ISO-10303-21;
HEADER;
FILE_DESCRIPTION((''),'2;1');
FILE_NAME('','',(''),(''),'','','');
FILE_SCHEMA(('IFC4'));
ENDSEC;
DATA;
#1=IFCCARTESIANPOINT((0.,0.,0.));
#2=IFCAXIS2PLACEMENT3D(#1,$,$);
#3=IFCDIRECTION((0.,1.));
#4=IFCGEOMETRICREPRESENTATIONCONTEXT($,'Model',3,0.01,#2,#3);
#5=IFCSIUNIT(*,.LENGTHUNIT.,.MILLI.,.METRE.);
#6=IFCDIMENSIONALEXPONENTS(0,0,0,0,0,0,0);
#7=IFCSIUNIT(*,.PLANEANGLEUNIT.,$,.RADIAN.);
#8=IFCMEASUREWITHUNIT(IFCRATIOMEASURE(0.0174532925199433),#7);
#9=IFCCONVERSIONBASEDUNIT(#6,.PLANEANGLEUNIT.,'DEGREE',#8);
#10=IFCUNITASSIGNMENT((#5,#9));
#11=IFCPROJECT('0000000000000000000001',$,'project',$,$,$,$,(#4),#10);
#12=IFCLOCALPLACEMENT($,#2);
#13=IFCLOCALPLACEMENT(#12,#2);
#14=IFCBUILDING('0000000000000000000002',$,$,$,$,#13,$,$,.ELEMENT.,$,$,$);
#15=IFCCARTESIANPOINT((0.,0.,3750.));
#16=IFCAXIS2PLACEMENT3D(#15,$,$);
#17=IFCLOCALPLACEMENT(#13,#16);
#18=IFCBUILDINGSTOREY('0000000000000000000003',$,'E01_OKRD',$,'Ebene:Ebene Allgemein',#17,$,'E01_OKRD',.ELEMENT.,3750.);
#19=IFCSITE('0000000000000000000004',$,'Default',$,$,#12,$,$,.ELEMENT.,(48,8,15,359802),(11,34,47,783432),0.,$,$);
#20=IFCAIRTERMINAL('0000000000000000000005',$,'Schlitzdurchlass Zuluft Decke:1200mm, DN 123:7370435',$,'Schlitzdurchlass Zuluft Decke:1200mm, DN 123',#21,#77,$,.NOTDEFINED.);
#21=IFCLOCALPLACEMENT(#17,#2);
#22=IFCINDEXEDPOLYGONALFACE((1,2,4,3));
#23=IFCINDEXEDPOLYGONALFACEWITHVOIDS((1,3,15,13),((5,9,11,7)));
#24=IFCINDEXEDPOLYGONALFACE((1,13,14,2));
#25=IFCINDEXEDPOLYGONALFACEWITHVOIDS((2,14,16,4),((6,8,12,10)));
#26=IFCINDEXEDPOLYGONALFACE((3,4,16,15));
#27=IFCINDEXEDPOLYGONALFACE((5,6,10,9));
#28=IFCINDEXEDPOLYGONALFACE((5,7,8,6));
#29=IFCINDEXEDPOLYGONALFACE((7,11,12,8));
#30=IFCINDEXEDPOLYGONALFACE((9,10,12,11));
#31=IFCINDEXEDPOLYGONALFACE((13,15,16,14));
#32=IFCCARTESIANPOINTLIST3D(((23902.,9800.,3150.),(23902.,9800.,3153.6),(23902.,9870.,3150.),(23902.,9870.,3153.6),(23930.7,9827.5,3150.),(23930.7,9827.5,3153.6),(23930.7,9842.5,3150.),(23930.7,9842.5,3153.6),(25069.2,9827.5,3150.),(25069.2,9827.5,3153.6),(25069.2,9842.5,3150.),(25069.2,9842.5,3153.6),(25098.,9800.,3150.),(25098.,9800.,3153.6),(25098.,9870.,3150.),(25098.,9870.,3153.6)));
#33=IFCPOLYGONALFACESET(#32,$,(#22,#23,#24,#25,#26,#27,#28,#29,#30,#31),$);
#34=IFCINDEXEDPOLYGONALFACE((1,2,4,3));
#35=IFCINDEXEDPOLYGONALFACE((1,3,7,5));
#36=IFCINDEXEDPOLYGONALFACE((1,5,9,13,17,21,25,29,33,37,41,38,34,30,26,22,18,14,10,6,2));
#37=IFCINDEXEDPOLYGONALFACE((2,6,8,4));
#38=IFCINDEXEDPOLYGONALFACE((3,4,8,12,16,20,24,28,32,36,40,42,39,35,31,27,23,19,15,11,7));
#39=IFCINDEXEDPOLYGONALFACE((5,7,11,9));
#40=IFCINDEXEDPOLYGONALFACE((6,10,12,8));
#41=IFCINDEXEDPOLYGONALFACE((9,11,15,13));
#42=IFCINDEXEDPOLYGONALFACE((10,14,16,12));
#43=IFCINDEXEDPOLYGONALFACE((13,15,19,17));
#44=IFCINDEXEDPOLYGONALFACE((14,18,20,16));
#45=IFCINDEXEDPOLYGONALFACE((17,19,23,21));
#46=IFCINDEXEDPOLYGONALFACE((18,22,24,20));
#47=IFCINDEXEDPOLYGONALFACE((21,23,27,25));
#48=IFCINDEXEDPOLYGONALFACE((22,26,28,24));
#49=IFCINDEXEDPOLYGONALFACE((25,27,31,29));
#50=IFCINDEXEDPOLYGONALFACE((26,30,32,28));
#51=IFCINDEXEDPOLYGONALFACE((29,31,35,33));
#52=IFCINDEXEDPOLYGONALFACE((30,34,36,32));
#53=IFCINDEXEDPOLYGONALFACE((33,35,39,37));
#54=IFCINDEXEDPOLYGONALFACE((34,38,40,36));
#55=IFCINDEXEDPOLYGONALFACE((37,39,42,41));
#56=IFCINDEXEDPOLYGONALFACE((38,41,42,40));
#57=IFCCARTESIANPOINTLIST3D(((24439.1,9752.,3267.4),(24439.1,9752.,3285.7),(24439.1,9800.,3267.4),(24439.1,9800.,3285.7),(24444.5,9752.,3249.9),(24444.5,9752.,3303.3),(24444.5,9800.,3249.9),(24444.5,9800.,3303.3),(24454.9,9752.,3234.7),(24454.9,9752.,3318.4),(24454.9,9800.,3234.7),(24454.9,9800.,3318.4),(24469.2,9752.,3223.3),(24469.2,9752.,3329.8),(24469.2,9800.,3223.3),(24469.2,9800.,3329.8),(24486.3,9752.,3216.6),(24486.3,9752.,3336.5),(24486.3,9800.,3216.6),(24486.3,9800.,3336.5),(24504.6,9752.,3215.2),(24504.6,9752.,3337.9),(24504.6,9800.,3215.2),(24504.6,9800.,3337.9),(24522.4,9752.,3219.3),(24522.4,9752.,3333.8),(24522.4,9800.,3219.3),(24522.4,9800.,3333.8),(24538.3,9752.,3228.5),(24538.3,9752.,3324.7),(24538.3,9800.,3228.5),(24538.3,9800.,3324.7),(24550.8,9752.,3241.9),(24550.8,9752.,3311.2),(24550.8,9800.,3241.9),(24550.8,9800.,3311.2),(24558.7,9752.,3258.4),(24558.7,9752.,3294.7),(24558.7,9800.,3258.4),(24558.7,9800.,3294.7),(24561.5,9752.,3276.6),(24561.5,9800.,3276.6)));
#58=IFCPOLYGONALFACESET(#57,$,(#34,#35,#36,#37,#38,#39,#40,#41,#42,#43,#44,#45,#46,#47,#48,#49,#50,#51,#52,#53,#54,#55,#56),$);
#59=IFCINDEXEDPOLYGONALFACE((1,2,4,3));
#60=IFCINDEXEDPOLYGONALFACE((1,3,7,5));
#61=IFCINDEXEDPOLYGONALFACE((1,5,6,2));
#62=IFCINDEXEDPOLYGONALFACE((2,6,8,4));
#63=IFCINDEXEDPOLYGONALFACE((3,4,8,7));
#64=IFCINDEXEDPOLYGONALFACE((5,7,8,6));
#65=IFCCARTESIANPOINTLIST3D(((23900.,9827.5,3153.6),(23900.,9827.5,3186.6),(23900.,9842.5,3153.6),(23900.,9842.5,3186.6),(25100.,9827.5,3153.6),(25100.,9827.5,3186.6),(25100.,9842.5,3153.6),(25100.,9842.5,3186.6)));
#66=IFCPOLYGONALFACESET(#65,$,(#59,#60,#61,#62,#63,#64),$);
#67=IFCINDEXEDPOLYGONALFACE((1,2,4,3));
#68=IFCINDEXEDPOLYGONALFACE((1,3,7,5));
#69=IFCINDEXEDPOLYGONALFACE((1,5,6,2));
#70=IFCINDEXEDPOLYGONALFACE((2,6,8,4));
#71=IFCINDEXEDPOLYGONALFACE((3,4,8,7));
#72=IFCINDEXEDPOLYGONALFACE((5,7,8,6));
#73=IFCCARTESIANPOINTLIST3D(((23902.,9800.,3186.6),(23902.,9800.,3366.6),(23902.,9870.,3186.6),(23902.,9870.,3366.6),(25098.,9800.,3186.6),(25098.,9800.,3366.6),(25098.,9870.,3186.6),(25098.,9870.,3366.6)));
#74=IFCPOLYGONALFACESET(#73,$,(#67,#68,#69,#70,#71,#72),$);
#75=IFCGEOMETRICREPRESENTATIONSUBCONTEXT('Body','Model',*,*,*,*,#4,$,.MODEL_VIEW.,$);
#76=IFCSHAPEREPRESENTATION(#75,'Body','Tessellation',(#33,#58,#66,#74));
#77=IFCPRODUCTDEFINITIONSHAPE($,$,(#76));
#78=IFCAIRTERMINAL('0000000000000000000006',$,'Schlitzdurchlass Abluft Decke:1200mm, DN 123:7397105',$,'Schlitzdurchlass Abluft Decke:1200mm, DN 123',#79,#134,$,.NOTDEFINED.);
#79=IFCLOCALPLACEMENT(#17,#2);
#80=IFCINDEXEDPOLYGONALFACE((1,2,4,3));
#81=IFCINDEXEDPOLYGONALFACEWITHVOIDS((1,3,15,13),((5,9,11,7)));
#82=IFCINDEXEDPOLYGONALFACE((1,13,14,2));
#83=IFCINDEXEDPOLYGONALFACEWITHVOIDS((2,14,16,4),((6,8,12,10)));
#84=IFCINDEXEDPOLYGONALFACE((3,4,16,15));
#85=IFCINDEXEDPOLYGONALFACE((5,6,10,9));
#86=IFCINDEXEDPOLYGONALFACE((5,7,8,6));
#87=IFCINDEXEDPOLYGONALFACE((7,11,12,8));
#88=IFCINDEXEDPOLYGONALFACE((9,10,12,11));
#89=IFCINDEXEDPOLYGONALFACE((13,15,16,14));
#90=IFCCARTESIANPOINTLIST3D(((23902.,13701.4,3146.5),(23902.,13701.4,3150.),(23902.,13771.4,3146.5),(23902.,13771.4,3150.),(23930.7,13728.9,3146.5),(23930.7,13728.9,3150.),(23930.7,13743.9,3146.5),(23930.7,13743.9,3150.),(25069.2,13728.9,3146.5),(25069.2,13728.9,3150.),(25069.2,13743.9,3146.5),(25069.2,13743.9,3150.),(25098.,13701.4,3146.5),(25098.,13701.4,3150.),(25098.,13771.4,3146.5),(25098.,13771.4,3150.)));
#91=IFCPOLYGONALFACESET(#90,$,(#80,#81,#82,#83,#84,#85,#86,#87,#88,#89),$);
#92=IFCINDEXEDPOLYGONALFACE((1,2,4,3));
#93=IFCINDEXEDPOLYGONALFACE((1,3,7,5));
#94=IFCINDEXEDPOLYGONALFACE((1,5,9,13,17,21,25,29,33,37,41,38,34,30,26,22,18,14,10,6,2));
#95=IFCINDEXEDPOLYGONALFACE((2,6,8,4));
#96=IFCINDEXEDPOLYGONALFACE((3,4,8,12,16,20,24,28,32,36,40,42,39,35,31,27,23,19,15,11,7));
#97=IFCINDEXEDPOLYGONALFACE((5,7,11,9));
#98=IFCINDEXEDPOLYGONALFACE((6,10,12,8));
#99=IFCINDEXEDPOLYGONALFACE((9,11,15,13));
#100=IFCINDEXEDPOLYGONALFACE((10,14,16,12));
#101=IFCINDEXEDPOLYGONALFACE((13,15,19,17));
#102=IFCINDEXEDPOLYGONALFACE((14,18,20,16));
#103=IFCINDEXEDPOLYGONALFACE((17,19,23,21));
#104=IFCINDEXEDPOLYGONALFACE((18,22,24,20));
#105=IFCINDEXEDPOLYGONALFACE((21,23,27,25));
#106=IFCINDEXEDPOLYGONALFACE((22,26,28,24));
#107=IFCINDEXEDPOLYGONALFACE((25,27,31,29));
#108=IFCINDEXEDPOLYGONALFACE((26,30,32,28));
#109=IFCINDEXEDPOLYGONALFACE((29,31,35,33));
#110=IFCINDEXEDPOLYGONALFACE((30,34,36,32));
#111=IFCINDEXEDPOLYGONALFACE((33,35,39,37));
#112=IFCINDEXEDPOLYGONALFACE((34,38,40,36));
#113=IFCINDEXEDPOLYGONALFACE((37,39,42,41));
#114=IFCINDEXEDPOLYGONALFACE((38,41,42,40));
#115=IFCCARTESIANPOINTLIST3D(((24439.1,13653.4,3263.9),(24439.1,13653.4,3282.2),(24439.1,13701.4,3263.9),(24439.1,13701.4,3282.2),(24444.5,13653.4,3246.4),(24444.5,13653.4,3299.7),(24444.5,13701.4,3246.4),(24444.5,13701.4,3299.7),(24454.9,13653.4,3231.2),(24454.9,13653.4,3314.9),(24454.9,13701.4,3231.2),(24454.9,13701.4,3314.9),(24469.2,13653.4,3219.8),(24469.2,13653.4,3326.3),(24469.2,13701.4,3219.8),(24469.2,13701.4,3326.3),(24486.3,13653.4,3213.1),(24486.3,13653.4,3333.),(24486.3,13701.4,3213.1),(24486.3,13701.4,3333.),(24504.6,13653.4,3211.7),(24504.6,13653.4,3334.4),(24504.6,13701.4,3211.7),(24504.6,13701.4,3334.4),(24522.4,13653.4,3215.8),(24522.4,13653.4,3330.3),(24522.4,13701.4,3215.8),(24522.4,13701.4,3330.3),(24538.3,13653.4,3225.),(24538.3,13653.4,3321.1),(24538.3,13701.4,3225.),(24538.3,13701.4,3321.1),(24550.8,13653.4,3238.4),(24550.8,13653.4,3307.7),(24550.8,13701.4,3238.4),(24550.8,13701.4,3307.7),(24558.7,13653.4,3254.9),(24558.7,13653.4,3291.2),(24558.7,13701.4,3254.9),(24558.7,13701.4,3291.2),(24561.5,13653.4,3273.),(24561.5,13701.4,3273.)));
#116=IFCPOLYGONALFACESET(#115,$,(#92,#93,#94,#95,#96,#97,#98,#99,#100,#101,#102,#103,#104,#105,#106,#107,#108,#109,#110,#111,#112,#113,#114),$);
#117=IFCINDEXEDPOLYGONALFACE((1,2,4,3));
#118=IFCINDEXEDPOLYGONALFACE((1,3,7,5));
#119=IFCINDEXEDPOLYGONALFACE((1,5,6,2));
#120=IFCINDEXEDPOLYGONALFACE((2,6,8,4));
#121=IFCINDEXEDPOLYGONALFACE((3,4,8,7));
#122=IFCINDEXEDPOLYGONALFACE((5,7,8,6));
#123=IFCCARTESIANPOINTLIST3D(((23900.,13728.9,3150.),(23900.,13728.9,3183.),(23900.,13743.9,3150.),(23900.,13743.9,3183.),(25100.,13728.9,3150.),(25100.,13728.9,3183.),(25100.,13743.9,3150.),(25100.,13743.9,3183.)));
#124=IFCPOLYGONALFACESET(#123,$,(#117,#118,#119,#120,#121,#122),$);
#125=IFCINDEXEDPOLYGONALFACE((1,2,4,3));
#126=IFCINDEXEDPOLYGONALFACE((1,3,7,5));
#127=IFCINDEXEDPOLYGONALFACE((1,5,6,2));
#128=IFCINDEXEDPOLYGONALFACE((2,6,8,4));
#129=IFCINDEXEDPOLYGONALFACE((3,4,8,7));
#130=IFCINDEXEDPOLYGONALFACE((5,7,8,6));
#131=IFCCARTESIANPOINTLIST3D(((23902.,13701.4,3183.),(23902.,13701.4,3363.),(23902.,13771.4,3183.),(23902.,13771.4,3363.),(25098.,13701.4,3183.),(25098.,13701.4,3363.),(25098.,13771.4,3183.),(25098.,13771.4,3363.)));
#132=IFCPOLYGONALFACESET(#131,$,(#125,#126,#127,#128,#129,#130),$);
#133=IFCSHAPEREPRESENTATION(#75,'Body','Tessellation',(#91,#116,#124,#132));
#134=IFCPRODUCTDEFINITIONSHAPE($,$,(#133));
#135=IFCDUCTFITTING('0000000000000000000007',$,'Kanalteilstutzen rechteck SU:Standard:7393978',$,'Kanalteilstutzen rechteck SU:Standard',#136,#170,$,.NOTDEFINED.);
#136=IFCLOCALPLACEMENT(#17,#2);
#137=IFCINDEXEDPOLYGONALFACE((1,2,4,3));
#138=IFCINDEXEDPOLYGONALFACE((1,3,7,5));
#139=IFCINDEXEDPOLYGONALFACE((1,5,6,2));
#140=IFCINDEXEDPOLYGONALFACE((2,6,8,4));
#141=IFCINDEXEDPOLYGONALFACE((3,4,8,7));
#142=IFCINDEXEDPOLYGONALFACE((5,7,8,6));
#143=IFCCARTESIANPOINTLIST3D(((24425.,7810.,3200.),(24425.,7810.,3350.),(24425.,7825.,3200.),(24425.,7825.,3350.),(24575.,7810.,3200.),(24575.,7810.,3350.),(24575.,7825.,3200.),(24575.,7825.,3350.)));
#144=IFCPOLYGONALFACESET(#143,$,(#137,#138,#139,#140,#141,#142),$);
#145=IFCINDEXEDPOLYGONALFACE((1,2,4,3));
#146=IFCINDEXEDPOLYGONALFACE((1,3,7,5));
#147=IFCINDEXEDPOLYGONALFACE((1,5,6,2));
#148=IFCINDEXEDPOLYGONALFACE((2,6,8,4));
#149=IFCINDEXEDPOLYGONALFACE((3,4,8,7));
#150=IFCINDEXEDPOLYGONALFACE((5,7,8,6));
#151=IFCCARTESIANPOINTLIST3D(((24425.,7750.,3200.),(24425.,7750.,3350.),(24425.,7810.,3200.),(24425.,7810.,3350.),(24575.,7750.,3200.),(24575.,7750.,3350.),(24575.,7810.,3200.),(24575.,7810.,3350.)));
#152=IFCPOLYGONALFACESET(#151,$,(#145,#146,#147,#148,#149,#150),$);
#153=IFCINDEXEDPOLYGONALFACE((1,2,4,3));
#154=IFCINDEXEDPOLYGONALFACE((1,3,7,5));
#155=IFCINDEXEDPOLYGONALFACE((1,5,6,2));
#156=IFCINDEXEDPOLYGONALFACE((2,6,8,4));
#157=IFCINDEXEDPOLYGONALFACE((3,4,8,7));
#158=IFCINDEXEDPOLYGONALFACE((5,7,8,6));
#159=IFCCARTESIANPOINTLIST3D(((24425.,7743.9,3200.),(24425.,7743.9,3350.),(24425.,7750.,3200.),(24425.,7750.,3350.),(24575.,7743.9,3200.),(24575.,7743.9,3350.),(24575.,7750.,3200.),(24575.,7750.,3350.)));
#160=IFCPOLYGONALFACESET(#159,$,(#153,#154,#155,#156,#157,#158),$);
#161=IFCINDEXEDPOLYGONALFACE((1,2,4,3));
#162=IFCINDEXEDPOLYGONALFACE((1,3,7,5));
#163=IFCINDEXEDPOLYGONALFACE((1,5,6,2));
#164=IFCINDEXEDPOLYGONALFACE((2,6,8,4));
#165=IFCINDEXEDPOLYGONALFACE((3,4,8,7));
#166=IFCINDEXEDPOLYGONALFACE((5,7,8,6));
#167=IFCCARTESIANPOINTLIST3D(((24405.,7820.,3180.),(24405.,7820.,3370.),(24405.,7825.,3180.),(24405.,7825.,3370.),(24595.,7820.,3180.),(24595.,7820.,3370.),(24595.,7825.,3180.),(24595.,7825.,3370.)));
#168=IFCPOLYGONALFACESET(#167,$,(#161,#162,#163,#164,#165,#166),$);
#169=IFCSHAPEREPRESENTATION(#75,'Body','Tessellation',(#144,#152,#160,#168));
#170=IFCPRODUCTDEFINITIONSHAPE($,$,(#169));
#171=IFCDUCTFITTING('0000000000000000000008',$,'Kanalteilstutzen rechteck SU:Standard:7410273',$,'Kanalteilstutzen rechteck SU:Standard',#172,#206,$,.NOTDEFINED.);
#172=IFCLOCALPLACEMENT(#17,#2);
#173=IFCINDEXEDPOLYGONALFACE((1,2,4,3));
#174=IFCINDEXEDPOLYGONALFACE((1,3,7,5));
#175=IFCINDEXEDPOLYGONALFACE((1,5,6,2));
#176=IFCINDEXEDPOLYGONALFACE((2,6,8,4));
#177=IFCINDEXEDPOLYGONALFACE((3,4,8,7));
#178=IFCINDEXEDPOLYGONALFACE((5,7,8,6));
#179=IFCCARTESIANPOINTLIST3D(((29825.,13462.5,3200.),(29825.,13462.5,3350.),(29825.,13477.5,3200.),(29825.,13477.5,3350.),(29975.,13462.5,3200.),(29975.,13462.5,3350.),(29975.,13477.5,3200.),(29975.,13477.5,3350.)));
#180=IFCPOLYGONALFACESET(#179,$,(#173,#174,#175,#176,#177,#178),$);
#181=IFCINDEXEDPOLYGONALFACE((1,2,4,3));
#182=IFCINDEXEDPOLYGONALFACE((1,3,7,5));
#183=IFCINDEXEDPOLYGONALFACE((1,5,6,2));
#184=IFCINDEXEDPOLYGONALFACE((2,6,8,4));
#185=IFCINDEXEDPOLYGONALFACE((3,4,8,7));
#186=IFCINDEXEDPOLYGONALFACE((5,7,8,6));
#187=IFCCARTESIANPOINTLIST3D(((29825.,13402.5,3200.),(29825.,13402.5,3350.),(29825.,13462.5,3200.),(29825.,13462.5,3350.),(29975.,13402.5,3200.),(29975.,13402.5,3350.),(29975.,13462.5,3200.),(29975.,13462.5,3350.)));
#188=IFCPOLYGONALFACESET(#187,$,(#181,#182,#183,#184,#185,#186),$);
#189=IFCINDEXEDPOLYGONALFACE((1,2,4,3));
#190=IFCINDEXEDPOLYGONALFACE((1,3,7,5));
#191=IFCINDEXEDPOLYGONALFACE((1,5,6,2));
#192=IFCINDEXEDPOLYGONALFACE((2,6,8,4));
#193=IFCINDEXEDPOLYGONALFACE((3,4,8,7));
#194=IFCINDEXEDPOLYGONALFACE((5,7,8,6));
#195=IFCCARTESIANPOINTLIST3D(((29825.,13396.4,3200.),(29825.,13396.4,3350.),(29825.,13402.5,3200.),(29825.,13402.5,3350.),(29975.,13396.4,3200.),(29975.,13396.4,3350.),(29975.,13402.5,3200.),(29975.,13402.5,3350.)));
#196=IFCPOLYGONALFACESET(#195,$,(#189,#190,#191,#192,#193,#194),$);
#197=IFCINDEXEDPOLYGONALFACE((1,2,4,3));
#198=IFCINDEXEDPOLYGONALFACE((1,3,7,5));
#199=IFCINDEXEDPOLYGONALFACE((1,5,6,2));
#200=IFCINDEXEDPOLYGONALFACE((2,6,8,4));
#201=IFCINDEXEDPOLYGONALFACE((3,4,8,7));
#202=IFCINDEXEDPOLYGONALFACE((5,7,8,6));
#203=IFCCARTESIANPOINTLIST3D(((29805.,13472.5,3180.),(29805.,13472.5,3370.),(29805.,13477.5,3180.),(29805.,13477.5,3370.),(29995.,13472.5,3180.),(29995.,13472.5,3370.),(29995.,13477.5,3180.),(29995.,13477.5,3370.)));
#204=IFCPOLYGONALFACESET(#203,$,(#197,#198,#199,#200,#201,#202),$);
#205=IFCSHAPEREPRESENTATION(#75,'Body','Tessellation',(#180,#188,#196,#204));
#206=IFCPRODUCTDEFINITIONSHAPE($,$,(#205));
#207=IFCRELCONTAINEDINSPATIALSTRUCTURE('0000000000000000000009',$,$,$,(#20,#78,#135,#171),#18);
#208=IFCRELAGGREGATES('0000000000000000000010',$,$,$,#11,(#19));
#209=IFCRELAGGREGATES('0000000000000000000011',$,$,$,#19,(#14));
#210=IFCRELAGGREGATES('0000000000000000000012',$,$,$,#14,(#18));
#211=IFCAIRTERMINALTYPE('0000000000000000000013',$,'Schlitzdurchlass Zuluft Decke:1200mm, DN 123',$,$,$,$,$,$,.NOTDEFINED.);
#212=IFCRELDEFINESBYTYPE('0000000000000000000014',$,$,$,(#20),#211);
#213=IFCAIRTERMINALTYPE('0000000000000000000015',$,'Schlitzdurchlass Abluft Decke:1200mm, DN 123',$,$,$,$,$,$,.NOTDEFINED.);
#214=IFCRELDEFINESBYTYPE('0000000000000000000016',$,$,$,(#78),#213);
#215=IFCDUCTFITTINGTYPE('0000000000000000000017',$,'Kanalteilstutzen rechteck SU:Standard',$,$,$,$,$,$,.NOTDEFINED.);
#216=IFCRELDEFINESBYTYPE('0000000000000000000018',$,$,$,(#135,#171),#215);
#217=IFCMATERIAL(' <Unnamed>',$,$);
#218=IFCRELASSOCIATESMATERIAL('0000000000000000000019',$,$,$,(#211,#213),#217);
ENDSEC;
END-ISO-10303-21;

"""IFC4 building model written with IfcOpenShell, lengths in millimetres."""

from ifc_helpers import new_model, entity, si_unit, converted_unit, direction, frame, frame_2d, origin, origin_2d_with_axis, place, context, subcontext, project, spatial, polyline, rectangle, circle, outline, extrude, source, transform, mapped, material, type_object, type_shapes, element, save


model = new_model("IFC4")

# Units and contexts
model_context = context("Model", 3, precision=0.01, world=origin(), true_north=direction((0.0, 1.0)))
body_context = subcontext(model_context, "Body", "Model", "MODEL_VIEW")
ifc_project = project(units=[si_unit("LENGTHUNIT", "METRE", prefix="MILLI"), converted_unit("PLANEANGLEUNIT", "DEGREE", entity("IfcRatioMeasure", 0.0174532925199433), si_unit("PLANEANGLEUNIT", "RADIAN"), dimensions=[0, 0, 0, 0, 0, 0, 0])], contexts=[model_context])

# Site, building, storey
site_placement = place(None, origin())
site = spatial("IfcSite", under=ifc_project, at=site_placement, Name="Default", CompositionType="ELEMENT", RefLatitude=(48, 8, 15, 359802), RefLongitude=(11, 34, 47, 783432), RefElevation=0.0)
building_placement = place(site_placement, origin())
building = spatial("IfcBuilding", under=site, at=building_placement, CompositionType="ELEMENT")
storey_placement = place(building_placement, frame((0.0, 0.0, 3750.0)))
storey = spatial("IfcBuildingStorey", under=building, at=storey_placement, Name="E01_OKRD", ObjectType="Ebene:Ebene Allgemein", LongName="E01_OKRD", CompositionType="ELEMENT", Elevation=3750.0)

# Air terminals
ifc_material_1 = material(Name=" <Unnamed>")
air_terminal_type_1 = type_object("IfcAirTerminalType", Name="Schlitzdurchlass Zuluft Decke:1200mm, DN 123", PredefinedType="NOTDEFINED", material=ifc_material_1)
shared_shape_1 = source(origin(), body_context, "Body", "SweptSolid", [
    extrude(outline(polyline([(-598.0, -35.0), (598.0, -35.0), (598.0, 35.0), (-598.0, 35.0), (-598.0, -35.0)]), holes=[polyline([(-569.2, -7.5), (-569.2, 7.5), (569.2, 7.5), (569.2, -7.5), (-569.2, -7.5)])]), frame((600.0, 35.0, 0.0), z_axis=(0.0, 0.0, 1.0), x_axis=(-1.0, 0.0, 0.0)), (0.0, 0.0, 1.0), 3.6),
    extrude(circle(Radius=61.5, at=frame_2d((0.0, 0.0), x_axis=(1.0, 0.0))), frame((600.0, 70.0, 126.6), z_axis=(0.0, 1.0, 0.0), x_axis=(-1.0, 0.0, 0.0)), (0.0, 0.0, 1.0), 48.0),
    extrude(rectangle(XDim=1200.0, YDim=15.0, at=origin_2d_with_axis()), frame((600.0, 35.0, 3.6), z_axis=(0.0, 0.0, 1.0), x_axis=(-1.0, 0.0, 0.0)), (0.0, 0.0, 1.0), 33.0),
    extrude(rectangle(XDim=1196.0, YDim=70.0, at=origin_2d_with_axis()), frame((600.0, 35.0, 36.6), z_axis=(0.0, 0.0, 1.0), x_axis=(-1.0, 0.0, 0.0)), (0.0, 0.0, 1.0), 180.0),
])
type_shapes(air_terminal_type_1, [shared_shape_1])
air_terminal_1_placement = place(storey_placement, frame((25100.0, 9870.0, 3150.0), z_axis=(0.0, 0.0, 1.0), x_axis=(-1.0, 0.0, 0.0)))
element("IfcAirTerminal", 1, at=air_terminal_1_placement, inside=storey, type_object=air_terminal_type_1, Name="Schlitzdurchlass Zuluft Decke:1200mm, DN 123:7370435", ObjectType="Schlitzdurchlass Zuluft Decke:1200mm, DN 123", PredefinedType="NOTDEFINED", context=body_context, shape_type="MappedRepresentation", body=[
    mapped(shared_shape_1, transform((0.0, 0.0, 0.0), scale=1.0)),
])
air_terminal_type_2 = type_object("IfcAirTerminalType", Name="Schlitzdurchlass Abluft Decke:1200mm, DN 123", PredefinedType="NOTDEFINED", material=ifc_material_1)
shared_shape_2 = source(origin(), body_context, "Body", "SweptSolid", [
    extrude(outline(polyline([(-598.0, -35.0), (598.0, -35.0), (598.0, 35.0), (-598.0, 35.0), (-598.0, -35.0)]), holes=[polyline([(-569.2, -7.5), (-569.2, 7.5), (569.2, 7.5), (569.2, -7.5), (-569.2, -7.5)])]), frame((0.0, 0.0, 0.0), z_axis=(0.0, 0.0, 1.0), x_axis=(-1.0, 0.0, 0.0)), (0.0, 0.0, 1.0), 3.6),
    extrude(circle(Radius=61.5, at=frame_2d((0.0, 0.0), x_axis=(1.0, 0.0))), frame((0.0, 35.0, 126.6), z_axis=(0.0, 1.0, 0.0), x_axis=(-1.0, 0.0, 0.0)), (0.0, 0.0, 1.0), 48.0),
    extrude(rectangle(XDim=1200.0, YDim=15.0, at=origin_2d_with_axis()), frame((0.0, 0.0, 3.6), z_axis=(0.0, 0.0, 1.0), x_axis=(-1.0, 0.0, 0.0)), (0.0, 0.0, 1.0), 33.0),
    extrude(rectangle(XDim=1196.0, YDim=70.0, at=origin_2d_with_axis()), frame((0.0, 0.0, 36.6), z_axis=(0.0, 0.0, 1.0), x_axis=(-1.0, 0.0, 0.0)), (0.0, 0.0, 1.0), 180.0),
])
type_shapes(air_terminal_type_2, [shared_shape_2])
air_terminal_2_placement = place(storey_placement, frame((24500.0, 13736.4, 3146.5), z_axis=(0.0, 0.0, 1.0), x_axis=(-1.0, 0.0, 0.0)))
element("IfcAirTerminal", 2, at=air_terminal_2_placement, inside=storey, type_object=air_terminal_type_2, Name="Schlitzdurchlass Abluft Decke:1200mm, DN 123:7397105", ObjectType="Schlitzdurchlass Abluft Decke:1200mm, DN 123", PredefinedType="NOTDEFINED", context=body_context, shape_type="MappedRepresentation", body=[
    mapped(shared_shape_2, transform((0.0, 0.0, 0.0), scale=1.0)),
])

# Duct fittings
duct_fitting_type_1 = type_object("IfcDuctFittingType", Name="Kanalteilstutzen rechteck SU:Standard", PredefinedType="NOTDEFINED")
shared_shape_3 = source(origin(), body_context, "Body", "SweptSolid", [
    extrude(rectangle(XDim=15.0, YDim=150.0, at=frame_2d((0.0, 0.0), x_axis=(1.0, 0.0))), frame((67.5, 0.0, -75.0)), (0.0, 0.0, 1.0), 150.0),
    extrude(rectangle(XDim=60.0, YDim=150.0, at=frame_2d((0.0, 0.0), x_axis=(1.0, 0.0))), frame((30.0, 0.0, -75.0)), (0.0, 0.0, 1.0), 150.0),
    extrude(rectangle(XDim=6.1, YDim=150.0, at=frame_2d((0.0, 0.0), x_axis=(1.0, 0.0))), frame((-3.0, 0.0, -75.0)), (0.0, 0.0, 1.0), 150.0),
    extrude(rectangle(XDim=5.0, YDim=190.0, at=origin_2d_with_axis()), frame((72.5, 0.0, -95.0)), (0.0, 0.0, 1.0), 190.0),
])
type_shapes(duct_fitting_type_1, [shared_shape_3])
for number, where, z_axis, x_axis, name in (
    (3, (24500.0, 7750.0, 3275.0), (0.0, 0.000025, -1.0), (0.0, 1.0, 0.000025), "Kanalteilstutzen rechteck SU:Standard:7393978"),
    (4, (29900.0, 13402.5, 3275.0), (0.0, 0.0, -1.0), (0.0, 1.0, 0.0), "Kanalteilstutzen rechteck SU:Standard:7410273"),
):
    element("IfcDuctFitting", number, at=place(storey_placement, frame(where, z_axis=z_axis, x_axis=x_axis)), inside=storey, type_object=duct_fitting_type_1, Name=name, ObjectType="Kanalteilstutzen rechteck SU:Standard", PredefinedType="NOTDEFINED", context=body_context, shape_type="MappedRepresentation", body=[
        mapped(shared_shape_3, transform((0.0, 0.0, 0.0), scale=1.0)),
    ])

save(model, "model.ifc")
